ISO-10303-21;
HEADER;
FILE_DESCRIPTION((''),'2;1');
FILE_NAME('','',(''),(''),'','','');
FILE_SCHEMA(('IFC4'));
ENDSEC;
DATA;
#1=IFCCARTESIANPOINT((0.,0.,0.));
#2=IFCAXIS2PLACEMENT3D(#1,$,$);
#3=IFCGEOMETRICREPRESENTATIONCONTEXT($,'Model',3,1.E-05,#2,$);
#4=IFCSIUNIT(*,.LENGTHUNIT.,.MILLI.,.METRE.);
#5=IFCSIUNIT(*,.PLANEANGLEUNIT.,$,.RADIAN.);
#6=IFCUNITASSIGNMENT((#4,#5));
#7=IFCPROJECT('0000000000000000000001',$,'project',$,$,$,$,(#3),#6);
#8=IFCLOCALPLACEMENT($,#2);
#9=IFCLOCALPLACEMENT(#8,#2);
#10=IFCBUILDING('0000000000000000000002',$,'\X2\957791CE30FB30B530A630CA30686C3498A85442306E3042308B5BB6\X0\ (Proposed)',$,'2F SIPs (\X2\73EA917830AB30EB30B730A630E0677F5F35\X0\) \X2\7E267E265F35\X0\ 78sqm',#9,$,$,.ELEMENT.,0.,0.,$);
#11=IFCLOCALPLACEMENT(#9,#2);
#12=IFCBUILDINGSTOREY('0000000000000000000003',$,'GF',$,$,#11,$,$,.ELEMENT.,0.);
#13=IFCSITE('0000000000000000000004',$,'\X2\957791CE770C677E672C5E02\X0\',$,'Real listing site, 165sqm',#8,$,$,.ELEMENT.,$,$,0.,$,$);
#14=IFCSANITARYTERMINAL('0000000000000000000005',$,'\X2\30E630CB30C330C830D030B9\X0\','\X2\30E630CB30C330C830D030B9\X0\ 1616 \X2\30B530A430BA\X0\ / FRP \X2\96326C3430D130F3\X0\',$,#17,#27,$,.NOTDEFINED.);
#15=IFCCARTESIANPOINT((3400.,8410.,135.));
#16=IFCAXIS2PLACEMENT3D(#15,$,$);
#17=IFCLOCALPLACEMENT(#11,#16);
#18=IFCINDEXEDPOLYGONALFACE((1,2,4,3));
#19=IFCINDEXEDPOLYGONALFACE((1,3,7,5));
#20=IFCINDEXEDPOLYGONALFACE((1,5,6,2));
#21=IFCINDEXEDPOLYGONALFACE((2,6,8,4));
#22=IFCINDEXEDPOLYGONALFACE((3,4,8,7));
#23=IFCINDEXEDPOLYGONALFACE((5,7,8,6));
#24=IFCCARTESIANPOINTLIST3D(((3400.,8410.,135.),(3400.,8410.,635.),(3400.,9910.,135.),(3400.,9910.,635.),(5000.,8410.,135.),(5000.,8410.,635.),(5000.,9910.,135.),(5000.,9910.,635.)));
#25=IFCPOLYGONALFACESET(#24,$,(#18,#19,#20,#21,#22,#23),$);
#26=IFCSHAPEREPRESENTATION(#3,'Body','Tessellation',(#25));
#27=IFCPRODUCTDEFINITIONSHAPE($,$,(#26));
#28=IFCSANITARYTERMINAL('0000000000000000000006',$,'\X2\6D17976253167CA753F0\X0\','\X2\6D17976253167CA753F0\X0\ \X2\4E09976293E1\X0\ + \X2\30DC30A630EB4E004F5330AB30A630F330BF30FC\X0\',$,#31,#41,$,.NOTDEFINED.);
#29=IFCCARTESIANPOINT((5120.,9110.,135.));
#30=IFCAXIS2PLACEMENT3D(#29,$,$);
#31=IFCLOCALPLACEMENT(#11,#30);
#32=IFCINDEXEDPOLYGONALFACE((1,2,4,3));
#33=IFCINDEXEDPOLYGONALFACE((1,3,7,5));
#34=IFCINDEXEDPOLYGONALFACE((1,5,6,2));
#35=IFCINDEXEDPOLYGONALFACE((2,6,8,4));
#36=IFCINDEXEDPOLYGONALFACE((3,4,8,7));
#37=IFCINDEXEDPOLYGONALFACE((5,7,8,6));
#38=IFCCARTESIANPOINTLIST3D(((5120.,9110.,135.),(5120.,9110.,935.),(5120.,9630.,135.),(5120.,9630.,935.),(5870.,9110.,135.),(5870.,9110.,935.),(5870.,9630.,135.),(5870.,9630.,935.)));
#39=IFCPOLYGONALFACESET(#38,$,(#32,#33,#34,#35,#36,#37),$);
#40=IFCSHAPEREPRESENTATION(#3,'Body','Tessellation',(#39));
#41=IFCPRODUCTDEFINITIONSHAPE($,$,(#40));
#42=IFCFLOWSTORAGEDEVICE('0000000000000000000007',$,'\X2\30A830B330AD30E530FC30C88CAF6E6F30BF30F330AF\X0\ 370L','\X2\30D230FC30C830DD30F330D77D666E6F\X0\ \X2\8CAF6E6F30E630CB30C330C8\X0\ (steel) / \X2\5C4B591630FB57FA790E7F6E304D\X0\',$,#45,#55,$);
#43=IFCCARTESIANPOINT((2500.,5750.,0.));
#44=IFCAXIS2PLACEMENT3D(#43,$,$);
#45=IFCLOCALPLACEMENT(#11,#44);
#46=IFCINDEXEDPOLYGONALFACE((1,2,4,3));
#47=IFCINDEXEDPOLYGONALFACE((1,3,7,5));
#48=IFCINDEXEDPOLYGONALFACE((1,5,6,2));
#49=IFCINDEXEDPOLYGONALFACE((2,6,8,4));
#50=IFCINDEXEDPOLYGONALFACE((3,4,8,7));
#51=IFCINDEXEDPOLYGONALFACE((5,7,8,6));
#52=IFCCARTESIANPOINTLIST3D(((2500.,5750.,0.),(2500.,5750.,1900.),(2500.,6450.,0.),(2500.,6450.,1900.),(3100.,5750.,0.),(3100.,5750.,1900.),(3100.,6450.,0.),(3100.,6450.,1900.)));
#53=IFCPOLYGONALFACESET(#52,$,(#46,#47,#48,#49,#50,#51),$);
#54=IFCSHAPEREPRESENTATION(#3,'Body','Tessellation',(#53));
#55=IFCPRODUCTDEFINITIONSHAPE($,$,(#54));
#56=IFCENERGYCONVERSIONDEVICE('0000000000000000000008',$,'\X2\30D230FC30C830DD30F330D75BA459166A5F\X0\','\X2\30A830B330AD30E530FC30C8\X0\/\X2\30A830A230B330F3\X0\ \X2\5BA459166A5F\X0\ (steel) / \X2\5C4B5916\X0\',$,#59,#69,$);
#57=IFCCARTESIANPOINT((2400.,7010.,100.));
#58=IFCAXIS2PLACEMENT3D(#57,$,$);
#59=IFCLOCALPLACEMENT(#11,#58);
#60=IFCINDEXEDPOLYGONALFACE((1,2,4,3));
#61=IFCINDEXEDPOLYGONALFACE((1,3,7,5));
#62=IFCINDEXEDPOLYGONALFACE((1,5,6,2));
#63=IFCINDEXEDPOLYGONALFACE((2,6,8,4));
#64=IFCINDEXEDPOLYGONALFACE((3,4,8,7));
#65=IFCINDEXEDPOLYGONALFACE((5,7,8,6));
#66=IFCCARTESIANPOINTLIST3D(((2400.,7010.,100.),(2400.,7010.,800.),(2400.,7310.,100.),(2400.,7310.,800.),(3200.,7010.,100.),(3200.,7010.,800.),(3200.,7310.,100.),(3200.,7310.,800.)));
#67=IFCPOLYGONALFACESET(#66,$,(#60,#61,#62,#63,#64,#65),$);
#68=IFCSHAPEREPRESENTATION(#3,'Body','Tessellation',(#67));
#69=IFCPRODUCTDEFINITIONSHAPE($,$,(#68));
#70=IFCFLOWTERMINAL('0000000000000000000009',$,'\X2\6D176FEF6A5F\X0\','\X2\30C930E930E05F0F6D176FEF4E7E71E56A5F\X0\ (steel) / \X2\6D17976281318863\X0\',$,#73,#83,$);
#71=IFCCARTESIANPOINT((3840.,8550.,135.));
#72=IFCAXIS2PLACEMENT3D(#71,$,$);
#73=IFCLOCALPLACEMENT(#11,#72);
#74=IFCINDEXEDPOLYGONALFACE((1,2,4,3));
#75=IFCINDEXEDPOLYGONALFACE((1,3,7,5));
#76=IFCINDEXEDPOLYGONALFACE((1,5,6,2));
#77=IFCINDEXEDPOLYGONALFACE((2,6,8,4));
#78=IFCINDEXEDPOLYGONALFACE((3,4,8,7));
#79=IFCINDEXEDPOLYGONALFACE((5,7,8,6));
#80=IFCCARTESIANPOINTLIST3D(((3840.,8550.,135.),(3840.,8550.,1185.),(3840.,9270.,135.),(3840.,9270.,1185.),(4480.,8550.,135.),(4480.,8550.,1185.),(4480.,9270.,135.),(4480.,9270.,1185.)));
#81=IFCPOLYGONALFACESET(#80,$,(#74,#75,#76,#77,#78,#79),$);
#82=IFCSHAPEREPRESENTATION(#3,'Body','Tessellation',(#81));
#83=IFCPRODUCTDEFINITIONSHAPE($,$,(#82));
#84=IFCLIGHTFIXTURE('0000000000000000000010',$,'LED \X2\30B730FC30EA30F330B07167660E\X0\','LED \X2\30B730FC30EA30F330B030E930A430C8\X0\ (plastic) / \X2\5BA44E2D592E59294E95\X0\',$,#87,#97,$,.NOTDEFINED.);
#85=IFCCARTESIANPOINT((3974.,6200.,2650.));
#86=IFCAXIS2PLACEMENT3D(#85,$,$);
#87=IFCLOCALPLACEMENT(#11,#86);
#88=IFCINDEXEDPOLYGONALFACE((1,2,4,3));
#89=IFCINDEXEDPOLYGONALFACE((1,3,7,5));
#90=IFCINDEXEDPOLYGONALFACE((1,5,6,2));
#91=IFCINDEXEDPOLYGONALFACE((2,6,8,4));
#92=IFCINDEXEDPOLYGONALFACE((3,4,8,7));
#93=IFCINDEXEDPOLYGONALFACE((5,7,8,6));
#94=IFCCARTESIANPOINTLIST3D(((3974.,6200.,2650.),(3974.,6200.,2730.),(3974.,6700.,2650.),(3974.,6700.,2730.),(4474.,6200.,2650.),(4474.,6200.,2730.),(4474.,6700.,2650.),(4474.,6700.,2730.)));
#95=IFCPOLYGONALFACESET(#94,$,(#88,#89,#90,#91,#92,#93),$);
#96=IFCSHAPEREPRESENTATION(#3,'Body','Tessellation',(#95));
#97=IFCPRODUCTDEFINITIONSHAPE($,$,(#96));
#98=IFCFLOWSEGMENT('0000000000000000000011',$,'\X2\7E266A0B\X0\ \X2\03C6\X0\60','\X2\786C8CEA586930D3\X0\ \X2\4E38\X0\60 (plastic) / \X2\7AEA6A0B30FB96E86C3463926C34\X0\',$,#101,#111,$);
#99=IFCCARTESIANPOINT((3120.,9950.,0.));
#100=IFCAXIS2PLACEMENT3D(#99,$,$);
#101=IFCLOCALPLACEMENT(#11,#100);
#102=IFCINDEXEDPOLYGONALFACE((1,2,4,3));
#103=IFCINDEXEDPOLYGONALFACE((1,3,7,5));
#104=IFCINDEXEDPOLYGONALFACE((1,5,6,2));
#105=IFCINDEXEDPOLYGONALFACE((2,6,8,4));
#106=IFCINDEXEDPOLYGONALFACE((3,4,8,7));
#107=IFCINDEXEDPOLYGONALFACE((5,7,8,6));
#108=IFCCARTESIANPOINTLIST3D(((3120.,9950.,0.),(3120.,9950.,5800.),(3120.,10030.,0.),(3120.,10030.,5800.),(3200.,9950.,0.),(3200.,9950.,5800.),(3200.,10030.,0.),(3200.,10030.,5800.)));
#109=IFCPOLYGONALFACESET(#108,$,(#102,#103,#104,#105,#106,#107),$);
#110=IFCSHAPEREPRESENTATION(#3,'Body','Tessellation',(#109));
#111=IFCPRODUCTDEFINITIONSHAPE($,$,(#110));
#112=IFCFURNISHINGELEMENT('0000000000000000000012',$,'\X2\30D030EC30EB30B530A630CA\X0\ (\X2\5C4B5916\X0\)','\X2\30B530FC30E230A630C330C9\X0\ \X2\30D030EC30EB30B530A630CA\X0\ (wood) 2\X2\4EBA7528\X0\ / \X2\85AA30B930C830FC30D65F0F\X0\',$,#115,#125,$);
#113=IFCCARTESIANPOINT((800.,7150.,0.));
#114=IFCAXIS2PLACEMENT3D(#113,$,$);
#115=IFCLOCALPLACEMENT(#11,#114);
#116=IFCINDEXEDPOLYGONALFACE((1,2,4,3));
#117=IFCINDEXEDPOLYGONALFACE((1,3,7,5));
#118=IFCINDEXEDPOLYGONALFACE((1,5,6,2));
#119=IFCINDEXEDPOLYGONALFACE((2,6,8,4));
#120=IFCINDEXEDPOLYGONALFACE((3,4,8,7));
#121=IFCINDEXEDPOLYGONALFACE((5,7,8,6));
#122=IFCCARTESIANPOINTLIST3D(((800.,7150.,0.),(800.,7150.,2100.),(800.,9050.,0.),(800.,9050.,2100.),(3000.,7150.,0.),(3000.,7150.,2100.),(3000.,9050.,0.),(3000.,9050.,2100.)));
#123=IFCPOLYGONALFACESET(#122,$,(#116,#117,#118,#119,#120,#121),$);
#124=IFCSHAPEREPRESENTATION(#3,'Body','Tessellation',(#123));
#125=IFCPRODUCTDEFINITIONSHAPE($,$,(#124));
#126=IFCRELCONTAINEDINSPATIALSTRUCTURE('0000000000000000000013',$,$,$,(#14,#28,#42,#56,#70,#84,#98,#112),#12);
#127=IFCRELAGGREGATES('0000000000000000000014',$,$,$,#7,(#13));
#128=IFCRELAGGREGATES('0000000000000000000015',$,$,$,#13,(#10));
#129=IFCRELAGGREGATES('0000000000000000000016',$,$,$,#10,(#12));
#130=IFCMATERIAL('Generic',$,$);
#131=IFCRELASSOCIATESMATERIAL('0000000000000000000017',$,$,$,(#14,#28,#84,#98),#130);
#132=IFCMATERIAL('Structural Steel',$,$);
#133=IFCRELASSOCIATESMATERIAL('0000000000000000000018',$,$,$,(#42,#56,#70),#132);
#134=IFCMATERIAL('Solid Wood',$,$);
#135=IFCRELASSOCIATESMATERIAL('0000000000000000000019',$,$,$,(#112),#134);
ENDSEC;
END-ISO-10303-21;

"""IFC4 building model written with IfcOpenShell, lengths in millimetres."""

from ifc_helpers import new_model, si_unit, frame, frame_2d, origin, place, context, project, spatial, rectangle, extrude, material, element, save


model = new_model("IFC4")

# Units and contexts
model_context = context("Model", 3, precision=1e-05, world=origin())
ifc_project = project(units=[si_unit("LENGTHUNIT", "METRE", prefix="MILLI"), si_unit("PLANEANGLEUNIT", "RADIAN")], contexts=[model_context])

# Site, building, storey
site_placement = place(None, origin())
site = spatial("IfcSite", under=ifc_project, at=site_placement, Name="長野県松本市", ObjectType="Real listing site, 165sqm", CompositionType="ELEMENT", RefElevation=0.0)
building_placement = place(site_placement, origin())
building = spatial("IfcBuilding", under=site, at=building_placement, Name="長野・サウナと水風呂のある家 (Proposed)", ObjectType="2F SIPs (珪酸カルシウム板張) 縦縦張 78sqm", CompositionType="ELEMENT", ElevationOfRefHeight=0.0, ElevationOfTerrain=0.0)
storey_placement = place(building_placement, origin())
storey = spatial("IfcBuildingStorey", under=building, at=storey_placement, Name="GF", CompositionType="ELEMENT", Elevation=0.0)

# Shared definitions
ifc_material_1 = material(Name="Solid Wood")

# Shared definitions
ifc_material_2 = material(Name="Generic")

# Sanitary terminals
sanitary_terminal_1_placement = place(storey_placement, frame((3400.0, 8410.0, 135.0)))
element("IfcSanitaryTerminal", 1, at=sanitary_terminal_1_placement, inside=storey, material=ifc_material_2, Name="ユニットバス", Description="ユニットバス 1616 サイズ / FRP 防水パン", PredefinedType="NOTDEFINED", context=model_context, shape_type="SweptSolid", body=[
    extrude(rectangle(XDim=1600.0, YDim=1500.0, at=frame_2d((800.0, 750.0))), frame((3400.0, 8410.0, 135.0)), (0.0, 0.0, 1.0), 500.0),
])
sanitary_terminal_2_placement = place(storey_placement, frame((5120.0, 9110.0, 135.0)))
element("IfcSanitaryTerminal", 2, at=sanitary_terminal_2_placement, inside=storey, material=ifc_material_2, Name="洗面化粧台", Description="洗面化粧台 三面鏡 + ボウル一体カウンター", PredefinedType="NOTDEFINED", context=model_context, shape_type="SweptSolid", body=[
    extrude(rectangle(XDim=750.0, YDim=520.0, at=frame_2d((375.0, 260.0))), frame((5120.0, 9110.0, 135.0)), (0.0, 0.0, 1.0), 800.0),
])

# Flow storage device
ifc_material_3 = material(Name="Structural Steel")
flow_storage_device_placement = place(storey_placement, frame((2500.0, 5750.0, 0.0)))
element("IfcFlowStorageDevice", 3, at=flow_storage_device_placement, inside=storey, material=ifc_material_3, Name="エコキュート貯湯タンク 370L", Description="ヒートポンプ給湯 貯湯ユニット (steel) / 屋外・基礎置き", context=model_context, shape_type="SweptSolid", body=[
    extrude(rectangle(XDim=600.0, YDim=700.0, at=frame_2d((300.0, 350.0))), frame((2500.0, 5750.0, 0.0)), (0.0, 0.0, 1.0), 1900.0),
])

# Energy conversion device
energy_conversion_device_placement = place(storey_placement, frame((2400.0, 7010.0, 100.0)))
element("IfcEnergyConversionDevice", 4, at=energy_conversion_device_placement, inside=storey, material=ifc_material_3, Name="ヒートポンプ室外機", Description="エコキュート/エアコン 室外機 (steel) / 屋外", context=model_context, shape_type="SweptSolid", body=[
    extrude(rectangle(XDim=800.0, YDim=300.0, at=frame_2d((400.0, 150.0))), frame((2400.0, 7010.0, 100.0)), (0.0, 0.0, 1.0), 700.0),
])

# Flow terminal
flow_terminal_placement = place(storey_placement, frame((3840.0, 8550.0, 135.0)))
element("IfcFlowTerminal", 5, at=flow_terminal_placement, inside=storey, material=ifc_material_3, Name="洗濯機", Description="ドラム式洗濯乾燥機 (steel) / 洗面脱衣", context=model_context, shape_type="SweptSolid", body=[
    extrude(rectangle(XDim=640.0, YDim=720.0, at=frame_2d((320.0, 360.0))), frame((3840.0, 8550.0, 135.0)), (0.0, 0.0, 1.0), 1050.0),
])

# Light fixture
light_fixture_placement = place(storey_placement, frame((3974.0, 6200.0, 2650.0)))
element("IfcLightFixture", 6, at=light_fixture_placement, inside=storey, material=ifc_material_2, Name="LED シーリング照明", Description="LED シーリングライト (plastic) / 室中央天井", PredefinedType="NOTDEFINED", context=model_context, shape_type="SweptSolid", body=[
    extrude(rectangle(XDim=500.0, YDim=500.0, at=frame_2d((250.0, 250.0))), frame((3974.0, 6200.0, 2650.0)), (0.0, 0.0, 1.0), 80.0),
])

# Flow segment
flow_segment_placement = place(storey_placement, frame((3120.0, 9950.0, 0.0)))
element("IfcFlowSegment", 7, at=flow_segment_placement, inside=storey, material=ifc_material_2, Name="縦樋 φ60", Description="硬質塩ビ 丸60 (plastic) / 竪樋・雨水排水", context=model_context, shape_type="SweptSolid", body=[
    extrude(rectangle(XDim=80.0, YDim=80.0, at=frame_2d((40.0, 40.0))), frame((3120.0, 9950.0, 0.0)), (0.0, 0.0, 1.0), 5800.0),
])

# Furnishing element
furnishing_placement = place(storey_placement, frame((800.0, 7150.0, 0.0)))
element("IfcFurnishingElement", 8, at=furnishing_placement, inside=storey, material=ifc_material_1, Name="バレルサウナ (屋外)", Description="サーモウッド バレルサウナ (wood) 2人用 / 薪ストーブ式", context=model_context, shape_type="SweptSolid", body=[
    extrude(rectangle(XDim=2200.0, YDim=1900.0, at=frame_2d((1100.0, 950.0))), frame((800.0, 7150.0, 0.0)), (0.0, 0.0, 1.0), 2100.0),
])

save(model, "model.ifc")
